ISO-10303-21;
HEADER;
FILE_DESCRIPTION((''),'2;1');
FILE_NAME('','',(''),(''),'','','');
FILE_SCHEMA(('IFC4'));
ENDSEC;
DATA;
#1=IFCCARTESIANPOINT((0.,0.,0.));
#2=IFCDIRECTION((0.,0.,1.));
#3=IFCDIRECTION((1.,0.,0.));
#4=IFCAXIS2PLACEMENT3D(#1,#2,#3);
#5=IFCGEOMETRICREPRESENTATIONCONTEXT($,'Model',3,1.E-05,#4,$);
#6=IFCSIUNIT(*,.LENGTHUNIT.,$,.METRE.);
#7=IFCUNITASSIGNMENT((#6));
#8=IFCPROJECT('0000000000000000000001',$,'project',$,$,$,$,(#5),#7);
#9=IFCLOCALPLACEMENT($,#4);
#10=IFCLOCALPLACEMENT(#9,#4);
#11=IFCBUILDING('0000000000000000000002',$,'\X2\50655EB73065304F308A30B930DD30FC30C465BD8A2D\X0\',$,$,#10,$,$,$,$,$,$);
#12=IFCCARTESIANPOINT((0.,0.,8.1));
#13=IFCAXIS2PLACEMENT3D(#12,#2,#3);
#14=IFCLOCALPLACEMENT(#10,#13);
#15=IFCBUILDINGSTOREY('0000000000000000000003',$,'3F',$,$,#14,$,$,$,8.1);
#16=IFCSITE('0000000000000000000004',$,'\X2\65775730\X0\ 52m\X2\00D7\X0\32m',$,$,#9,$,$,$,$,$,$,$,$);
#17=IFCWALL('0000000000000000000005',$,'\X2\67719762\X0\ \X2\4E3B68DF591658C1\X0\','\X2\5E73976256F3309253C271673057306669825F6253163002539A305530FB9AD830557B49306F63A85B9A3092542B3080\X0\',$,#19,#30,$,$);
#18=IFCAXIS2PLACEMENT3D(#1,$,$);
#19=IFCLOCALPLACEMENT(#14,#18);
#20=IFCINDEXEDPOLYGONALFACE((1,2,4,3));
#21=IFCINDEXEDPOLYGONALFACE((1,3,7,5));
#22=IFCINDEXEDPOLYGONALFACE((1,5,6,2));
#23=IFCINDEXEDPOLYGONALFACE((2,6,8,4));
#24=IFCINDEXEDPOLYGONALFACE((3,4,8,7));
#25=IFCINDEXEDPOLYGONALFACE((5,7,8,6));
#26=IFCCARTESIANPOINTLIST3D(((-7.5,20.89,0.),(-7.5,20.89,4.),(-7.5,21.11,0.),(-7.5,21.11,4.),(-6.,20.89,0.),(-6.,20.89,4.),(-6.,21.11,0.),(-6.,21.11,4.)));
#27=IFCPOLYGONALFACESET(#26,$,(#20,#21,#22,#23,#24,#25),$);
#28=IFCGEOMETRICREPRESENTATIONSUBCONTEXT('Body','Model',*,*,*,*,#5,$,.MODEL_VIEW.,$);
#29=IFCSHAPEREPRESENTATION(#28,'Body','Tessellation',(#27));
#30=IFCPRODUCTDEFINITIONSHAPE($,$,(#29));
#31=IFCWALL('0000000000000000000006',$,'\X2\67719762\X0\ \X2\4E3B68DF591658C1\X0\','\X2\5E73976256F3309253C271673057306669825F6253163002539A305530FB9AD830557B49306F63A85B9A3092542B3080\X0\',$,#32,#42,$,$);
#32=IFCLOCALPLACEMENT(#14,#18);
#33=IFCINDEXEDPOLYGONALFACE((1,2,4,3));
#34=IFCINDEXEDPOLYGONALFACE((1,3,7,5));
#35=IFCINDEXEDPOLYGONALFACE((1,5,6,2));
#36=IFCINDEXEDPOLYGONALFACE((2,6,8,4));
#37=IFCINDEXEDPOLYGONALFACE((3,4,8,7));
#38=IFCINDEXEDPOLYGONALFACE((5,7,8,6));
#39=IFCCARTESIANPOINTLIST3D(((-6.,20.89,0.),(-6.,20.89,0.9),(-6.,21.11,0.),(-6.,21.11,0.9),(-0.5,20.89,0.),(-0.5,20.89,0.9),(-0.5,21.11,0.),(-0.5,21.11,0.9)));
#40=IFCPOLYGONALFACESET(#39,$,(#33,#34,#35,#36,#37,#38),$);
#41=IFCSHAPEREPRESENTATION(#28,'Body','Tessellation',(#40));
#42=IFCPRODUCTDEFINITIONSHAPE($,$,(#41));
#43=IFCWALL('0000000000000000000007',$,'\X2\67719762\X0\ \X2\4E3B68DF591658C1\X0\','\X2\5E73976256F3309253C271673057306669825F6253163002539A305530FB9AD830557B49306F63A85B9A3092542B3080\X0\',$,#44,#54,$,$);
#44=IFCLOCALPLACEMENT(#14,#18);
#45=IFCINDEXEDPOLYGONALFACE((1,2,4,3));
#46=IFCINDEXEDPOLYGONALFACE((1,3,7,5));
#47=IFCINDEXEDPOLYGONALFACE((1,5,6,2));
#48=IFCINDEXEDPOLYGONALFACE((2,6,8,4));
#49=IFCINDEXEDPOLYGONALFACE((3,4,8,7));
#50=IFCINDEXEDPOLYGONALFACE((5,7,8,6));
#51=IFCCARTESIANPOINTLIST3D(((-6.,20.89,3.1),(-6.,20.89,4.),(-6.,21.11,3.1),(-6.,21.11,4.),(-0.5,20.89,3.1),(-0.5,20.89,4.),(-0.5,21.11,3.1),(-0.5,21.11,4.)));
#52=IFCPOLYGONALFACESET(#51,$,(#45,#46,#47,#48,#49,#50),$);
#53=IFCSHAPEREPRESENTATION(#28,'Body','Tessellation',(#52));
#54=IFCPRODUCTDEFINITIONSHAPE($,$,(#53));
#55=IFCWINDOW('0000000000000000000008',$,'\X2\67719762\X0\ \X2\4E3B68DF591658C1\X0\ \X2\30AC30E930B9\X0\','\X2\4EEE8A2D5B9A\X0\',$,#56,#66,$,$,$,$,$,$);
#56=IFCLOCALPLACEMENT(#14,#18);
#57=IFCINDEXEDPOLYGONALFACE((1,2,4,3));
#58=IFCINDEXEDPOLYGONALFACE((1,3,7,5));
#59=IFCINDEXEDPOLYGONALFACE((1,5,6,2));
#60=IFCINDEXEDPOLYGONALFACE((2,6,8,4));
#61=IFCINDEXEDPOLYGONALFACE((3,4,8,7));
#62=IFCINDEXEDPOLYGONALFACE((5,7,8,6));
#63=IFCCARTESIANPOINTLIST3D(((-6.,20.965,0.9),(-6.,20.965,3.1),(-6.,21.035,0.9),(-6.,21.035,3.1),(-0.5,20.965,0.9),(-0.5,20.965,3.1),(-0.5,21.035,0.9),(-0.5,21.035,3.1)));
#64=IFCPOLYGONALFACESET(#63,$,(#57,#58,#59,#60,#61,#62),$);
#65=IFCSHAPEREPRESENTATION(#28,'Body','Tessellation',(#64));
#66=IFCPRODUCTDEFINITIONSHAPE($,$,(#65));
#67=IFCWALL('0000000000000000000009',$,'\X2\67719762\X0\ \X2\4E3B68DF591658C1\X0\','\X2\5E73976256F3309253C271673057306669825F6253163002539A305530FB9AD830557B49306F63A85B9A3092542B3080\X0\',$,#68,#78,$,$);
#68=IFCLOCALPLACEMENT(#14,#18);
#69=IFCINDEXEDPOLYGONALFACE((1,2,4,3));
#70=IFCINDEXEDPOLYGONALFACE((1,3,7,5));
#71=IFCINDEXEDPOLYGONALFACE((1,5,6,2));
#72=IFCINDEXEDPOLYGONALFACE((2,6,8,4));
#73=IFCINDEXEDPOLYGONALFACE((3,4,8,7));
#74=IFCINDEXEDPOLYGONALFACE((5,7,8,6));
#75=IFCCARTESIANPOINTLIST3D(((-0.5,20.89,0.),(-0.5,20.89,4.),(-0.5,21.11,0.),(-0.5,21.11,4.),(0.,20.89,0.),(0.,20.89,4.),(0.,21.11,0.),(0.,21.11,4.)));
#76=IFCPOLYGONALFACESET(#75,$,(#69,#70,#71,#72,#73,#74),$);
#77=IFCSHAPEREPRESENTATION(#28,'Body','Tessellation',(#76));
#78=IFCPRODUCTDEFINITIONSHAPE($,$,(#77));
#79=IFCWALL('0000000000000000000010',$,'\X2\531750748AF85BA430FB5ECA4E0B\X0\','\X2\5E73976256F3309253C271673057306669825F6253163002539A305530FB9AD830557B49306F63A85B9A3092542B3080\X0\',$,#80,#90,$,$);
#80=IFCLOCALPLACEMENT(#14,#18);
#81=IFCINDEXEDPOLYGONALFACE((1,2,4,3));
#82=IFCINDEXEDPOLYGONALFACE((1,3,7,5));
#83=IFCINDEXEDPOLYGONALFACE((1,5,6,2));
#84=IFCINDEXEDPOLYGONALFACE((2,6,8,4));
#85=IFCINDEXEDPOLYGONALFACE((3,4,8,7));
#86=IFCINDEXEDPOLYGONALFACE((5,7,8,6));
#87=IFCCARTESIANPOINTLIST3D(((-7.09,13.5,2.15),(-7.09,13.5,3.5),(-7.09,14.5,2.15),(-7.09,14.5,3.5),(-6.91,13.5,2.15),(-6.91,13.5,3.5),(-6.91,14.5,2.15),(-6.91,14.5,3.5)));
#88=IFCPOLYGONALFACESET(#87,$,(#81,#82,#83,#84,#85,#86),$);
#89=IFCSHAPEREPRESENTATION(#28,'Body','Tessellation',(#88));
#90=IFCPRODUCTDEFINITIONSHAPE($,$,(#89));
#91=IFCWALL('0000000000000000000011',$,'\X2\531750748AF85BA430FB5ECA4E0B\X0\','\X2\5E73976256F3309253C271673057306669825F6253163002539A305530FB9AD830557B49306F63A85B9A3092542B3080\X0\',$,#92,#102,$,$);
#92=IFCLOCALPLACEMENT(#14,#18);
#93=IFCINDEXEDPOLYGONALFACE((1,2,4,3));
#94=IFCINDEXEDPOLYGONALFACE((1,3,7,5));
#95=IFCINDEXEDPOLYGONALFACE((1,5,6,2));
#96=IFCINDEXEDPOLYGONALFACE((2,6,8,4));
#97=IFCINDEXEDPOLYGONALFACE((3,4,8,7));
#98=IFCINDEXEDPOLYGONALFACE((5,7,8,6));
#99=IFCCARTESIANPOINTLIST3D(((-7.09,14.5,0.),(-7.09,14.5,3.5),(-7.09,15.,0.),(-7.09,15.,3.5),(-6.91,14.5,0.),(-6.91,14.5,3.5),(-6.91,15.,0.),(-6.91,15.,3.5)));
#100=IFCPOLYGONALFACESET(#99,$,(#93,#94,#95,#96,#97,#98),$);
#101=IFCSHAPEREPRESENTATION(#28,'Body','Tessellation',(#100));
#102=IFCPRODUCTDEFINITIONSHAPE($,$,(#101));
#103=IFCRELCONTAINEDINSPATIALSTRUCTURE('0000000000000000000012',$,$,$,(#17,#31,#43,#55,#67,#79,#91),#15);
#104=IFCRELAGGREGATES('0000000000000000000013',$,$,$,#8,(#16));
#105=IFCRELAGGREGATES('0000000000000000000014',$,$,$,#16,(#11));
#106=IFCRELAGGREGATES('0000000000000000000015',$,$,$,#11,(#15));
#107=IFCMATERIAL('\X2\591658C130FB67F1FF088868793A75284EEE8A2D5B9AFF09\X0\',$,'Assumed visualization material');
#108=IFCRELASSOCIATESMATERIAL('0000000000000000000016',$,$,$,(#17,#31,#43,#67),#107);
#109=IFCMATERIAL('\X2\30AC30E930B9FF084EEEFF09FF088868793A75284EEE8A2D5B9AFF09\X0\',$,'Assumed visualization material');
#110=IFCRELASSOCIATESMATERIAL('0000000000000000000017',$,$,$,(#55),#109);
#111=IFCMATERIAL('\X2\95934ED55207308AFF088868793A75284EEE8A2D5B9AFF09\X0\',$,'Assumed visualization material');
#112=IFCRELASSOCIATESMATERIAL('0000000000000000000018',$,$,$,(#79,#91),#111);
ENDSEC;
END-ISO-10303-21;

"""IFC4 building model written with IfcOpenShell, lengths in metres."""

from ifc_helpers import new_model, si_unit, frame, origin_with_axes, place, context, subcontext, project, spatial, rectangle, extrude, material, element, save


model = new_model("IFC4")

# Units and contexts
model_context = context("Model", 3, precision=1e-05, world=origin_with_axes())
body_context = subcontext(model_context, "Body", "Model", "MODEL_VIEW")
ifc_project = project(units=[si_unit("LENGTHUNIT", "METRE")], contexts=[model_context])

# Site, building, storey
site_placement = place(None, origin_with_axes())
site = spatial("IfcSite", under=ifc_project, at=site_placement, Name="敷地 52m×32m")
building_placement = place(site_placement, origin_with_axes())
building = spatial("IfcBuilding", under=site, at=building_placement, Name="健康づくりスポーツ施設")
storey_placement = place(building_placement, frame((0.0, 0.0, 8.1), z_axis=(0.0, 0.0, 1.0), x_axis=(1.0, 0.0, 0.0)))
storey = spatial("IfcBuildingStorey", under=building, at=storey_placement, Name="3F", Elevation=8.1)

# Walls
ifc_material_1 = material(Name="外壁・柱（表示用仮設定）", Category="Assumed visualization material")
wall_1_placement = place(storey_placement, frame((-6.75, 21.0, 0.0), z_axis=(0.0, 0.0, 1.0), x_axis=(1.0, 0.0, 0.0)))
element("IfcWall", 1, at=wall_1_placement, inside=storey, material=ifc_material_1, Name="東面 主棟外壁", Description="平面図を参照して概形化。厚さ・高さ等は推定を含む", context=body_context, shape_type="SweptSolid", body=[
    extrude(rectangle(XDim=1.5, YDim=0.22), origin_with_axes(), (0.0, 0.0, 1.0), 4.0),
])
for number, where, z_axis, x_axis, name in (
    (2, (-3.25, 21.0, 0.0), (0.0, 0.0, 1.0), (1.0, 0.0, 0.0), "東面 主棟外壁"),
    (3, (-3.25, 21.0, 3.1), (0.0, 0.0, 1.0), (1.0, 0.0, 0.0), "東面 主棟外壁"),
):
    element("IfcWall", number, at=place(storey_placement, frame(where, z_axis=z_axis, x_axis=x_axis)), inside=storey, material=ifc_material_1, Name=name, Description="平面図を参照して概形化。厚さ・高さ等は推定を含む", context=body_context, shape_type="SweptSolid", body=[
        extrude(rectangle(XDim=5.5, YDim=0.22), origin_with_axes(), (0.0, 0.0, 1.0), 0.9),
    ])

# Window
ifc_material_2 = material(Name="ガラス（仮）（表示用仮設定）", Category="Assumed visualization material")
window_placement = place(storey_placement, frame((-3.25, 21.0, 0.9), z_axis=(0.0, 0.0, 1.0), x_axis=(1.0, 0.0, 0.0)))
element("IfcWindow", 4, at=window_placement, inside=storey, material=ifc_material_2, Name="東面 主棟外壁 ガラス", Description="仮設定", context=body_context, shape_type="SweptSolid", body=[
    extrude(rectangle(XDim=5.5, YDim=0.07), origin_with_axes(), (0.0, 0.0, 1.0), 2.2),
])

# Walls
wall_2_placement = place(storey_placement, frame((-0.25, 21.0, 0.0), z_axis=(0.0, 0.0, 1.0), x_axis=(1.0, 0.0, 0.0)))
element("IfcWall", 5, at=wall_2_placement, inside=storey, material=ifc_material_1, Name="東面 主棟外壁", Description="平面図を参照して概形化。厚さ・高さ等は推定を含む", context=body_context, shape_type="SweptSolid", body=[
    extrude(rectangle(XDim=0.5, YDim=0.22), origin_with_axes(), (0.0, 0.0, 1.0), 4.0),
])
ifc_material_3 = material(Name="間仕切り（表示用仮設定）", Category="Assumed visualization material")
wall_3_placement = place(storey_placement, frame((-7.0, 14.0, 2.15), z_axis=(0.0, 0.0, 1.0), x_axis=(1.0, 0.0, 0.0)))
element("IfcWall", 6, at=wall_3_placement, inside=storey, material=ifc_material_3, Name="北側諸室・廊下", Description="平面図を参照して概形化。厚さ・高さ等は推定を含む", context=body_context, shape_type="SweptSolid", body=[
    extrude(rectangle(XDim=0.18, YDim=1.0), origin_with_axes(), (0.0, 0.0, 1.0), 1.35),
])
wall_4_placement = place(storey_placement, frame((-7.0, 14.75, 0.0), z_axis=(0.0, 0.0, 1.0), x_axis=(1.0, 0.0, 0.0)))
element("IfcWall", 7, at=wall_4_placement, inside=storey, material=ifc_material_3, Name="北側諸室・廊下", Description="平面図を参照して概形化。厚さ・高さ等は推定を含む", context=body_context, shape_type="SweptSolid", body=[
    extrude(rectangle(XDim=0.18, YDim=0.5), origin_with_axes(), (0.0, 0.0, 1.0), 3.5),
])

save(model, "model.ifc")
